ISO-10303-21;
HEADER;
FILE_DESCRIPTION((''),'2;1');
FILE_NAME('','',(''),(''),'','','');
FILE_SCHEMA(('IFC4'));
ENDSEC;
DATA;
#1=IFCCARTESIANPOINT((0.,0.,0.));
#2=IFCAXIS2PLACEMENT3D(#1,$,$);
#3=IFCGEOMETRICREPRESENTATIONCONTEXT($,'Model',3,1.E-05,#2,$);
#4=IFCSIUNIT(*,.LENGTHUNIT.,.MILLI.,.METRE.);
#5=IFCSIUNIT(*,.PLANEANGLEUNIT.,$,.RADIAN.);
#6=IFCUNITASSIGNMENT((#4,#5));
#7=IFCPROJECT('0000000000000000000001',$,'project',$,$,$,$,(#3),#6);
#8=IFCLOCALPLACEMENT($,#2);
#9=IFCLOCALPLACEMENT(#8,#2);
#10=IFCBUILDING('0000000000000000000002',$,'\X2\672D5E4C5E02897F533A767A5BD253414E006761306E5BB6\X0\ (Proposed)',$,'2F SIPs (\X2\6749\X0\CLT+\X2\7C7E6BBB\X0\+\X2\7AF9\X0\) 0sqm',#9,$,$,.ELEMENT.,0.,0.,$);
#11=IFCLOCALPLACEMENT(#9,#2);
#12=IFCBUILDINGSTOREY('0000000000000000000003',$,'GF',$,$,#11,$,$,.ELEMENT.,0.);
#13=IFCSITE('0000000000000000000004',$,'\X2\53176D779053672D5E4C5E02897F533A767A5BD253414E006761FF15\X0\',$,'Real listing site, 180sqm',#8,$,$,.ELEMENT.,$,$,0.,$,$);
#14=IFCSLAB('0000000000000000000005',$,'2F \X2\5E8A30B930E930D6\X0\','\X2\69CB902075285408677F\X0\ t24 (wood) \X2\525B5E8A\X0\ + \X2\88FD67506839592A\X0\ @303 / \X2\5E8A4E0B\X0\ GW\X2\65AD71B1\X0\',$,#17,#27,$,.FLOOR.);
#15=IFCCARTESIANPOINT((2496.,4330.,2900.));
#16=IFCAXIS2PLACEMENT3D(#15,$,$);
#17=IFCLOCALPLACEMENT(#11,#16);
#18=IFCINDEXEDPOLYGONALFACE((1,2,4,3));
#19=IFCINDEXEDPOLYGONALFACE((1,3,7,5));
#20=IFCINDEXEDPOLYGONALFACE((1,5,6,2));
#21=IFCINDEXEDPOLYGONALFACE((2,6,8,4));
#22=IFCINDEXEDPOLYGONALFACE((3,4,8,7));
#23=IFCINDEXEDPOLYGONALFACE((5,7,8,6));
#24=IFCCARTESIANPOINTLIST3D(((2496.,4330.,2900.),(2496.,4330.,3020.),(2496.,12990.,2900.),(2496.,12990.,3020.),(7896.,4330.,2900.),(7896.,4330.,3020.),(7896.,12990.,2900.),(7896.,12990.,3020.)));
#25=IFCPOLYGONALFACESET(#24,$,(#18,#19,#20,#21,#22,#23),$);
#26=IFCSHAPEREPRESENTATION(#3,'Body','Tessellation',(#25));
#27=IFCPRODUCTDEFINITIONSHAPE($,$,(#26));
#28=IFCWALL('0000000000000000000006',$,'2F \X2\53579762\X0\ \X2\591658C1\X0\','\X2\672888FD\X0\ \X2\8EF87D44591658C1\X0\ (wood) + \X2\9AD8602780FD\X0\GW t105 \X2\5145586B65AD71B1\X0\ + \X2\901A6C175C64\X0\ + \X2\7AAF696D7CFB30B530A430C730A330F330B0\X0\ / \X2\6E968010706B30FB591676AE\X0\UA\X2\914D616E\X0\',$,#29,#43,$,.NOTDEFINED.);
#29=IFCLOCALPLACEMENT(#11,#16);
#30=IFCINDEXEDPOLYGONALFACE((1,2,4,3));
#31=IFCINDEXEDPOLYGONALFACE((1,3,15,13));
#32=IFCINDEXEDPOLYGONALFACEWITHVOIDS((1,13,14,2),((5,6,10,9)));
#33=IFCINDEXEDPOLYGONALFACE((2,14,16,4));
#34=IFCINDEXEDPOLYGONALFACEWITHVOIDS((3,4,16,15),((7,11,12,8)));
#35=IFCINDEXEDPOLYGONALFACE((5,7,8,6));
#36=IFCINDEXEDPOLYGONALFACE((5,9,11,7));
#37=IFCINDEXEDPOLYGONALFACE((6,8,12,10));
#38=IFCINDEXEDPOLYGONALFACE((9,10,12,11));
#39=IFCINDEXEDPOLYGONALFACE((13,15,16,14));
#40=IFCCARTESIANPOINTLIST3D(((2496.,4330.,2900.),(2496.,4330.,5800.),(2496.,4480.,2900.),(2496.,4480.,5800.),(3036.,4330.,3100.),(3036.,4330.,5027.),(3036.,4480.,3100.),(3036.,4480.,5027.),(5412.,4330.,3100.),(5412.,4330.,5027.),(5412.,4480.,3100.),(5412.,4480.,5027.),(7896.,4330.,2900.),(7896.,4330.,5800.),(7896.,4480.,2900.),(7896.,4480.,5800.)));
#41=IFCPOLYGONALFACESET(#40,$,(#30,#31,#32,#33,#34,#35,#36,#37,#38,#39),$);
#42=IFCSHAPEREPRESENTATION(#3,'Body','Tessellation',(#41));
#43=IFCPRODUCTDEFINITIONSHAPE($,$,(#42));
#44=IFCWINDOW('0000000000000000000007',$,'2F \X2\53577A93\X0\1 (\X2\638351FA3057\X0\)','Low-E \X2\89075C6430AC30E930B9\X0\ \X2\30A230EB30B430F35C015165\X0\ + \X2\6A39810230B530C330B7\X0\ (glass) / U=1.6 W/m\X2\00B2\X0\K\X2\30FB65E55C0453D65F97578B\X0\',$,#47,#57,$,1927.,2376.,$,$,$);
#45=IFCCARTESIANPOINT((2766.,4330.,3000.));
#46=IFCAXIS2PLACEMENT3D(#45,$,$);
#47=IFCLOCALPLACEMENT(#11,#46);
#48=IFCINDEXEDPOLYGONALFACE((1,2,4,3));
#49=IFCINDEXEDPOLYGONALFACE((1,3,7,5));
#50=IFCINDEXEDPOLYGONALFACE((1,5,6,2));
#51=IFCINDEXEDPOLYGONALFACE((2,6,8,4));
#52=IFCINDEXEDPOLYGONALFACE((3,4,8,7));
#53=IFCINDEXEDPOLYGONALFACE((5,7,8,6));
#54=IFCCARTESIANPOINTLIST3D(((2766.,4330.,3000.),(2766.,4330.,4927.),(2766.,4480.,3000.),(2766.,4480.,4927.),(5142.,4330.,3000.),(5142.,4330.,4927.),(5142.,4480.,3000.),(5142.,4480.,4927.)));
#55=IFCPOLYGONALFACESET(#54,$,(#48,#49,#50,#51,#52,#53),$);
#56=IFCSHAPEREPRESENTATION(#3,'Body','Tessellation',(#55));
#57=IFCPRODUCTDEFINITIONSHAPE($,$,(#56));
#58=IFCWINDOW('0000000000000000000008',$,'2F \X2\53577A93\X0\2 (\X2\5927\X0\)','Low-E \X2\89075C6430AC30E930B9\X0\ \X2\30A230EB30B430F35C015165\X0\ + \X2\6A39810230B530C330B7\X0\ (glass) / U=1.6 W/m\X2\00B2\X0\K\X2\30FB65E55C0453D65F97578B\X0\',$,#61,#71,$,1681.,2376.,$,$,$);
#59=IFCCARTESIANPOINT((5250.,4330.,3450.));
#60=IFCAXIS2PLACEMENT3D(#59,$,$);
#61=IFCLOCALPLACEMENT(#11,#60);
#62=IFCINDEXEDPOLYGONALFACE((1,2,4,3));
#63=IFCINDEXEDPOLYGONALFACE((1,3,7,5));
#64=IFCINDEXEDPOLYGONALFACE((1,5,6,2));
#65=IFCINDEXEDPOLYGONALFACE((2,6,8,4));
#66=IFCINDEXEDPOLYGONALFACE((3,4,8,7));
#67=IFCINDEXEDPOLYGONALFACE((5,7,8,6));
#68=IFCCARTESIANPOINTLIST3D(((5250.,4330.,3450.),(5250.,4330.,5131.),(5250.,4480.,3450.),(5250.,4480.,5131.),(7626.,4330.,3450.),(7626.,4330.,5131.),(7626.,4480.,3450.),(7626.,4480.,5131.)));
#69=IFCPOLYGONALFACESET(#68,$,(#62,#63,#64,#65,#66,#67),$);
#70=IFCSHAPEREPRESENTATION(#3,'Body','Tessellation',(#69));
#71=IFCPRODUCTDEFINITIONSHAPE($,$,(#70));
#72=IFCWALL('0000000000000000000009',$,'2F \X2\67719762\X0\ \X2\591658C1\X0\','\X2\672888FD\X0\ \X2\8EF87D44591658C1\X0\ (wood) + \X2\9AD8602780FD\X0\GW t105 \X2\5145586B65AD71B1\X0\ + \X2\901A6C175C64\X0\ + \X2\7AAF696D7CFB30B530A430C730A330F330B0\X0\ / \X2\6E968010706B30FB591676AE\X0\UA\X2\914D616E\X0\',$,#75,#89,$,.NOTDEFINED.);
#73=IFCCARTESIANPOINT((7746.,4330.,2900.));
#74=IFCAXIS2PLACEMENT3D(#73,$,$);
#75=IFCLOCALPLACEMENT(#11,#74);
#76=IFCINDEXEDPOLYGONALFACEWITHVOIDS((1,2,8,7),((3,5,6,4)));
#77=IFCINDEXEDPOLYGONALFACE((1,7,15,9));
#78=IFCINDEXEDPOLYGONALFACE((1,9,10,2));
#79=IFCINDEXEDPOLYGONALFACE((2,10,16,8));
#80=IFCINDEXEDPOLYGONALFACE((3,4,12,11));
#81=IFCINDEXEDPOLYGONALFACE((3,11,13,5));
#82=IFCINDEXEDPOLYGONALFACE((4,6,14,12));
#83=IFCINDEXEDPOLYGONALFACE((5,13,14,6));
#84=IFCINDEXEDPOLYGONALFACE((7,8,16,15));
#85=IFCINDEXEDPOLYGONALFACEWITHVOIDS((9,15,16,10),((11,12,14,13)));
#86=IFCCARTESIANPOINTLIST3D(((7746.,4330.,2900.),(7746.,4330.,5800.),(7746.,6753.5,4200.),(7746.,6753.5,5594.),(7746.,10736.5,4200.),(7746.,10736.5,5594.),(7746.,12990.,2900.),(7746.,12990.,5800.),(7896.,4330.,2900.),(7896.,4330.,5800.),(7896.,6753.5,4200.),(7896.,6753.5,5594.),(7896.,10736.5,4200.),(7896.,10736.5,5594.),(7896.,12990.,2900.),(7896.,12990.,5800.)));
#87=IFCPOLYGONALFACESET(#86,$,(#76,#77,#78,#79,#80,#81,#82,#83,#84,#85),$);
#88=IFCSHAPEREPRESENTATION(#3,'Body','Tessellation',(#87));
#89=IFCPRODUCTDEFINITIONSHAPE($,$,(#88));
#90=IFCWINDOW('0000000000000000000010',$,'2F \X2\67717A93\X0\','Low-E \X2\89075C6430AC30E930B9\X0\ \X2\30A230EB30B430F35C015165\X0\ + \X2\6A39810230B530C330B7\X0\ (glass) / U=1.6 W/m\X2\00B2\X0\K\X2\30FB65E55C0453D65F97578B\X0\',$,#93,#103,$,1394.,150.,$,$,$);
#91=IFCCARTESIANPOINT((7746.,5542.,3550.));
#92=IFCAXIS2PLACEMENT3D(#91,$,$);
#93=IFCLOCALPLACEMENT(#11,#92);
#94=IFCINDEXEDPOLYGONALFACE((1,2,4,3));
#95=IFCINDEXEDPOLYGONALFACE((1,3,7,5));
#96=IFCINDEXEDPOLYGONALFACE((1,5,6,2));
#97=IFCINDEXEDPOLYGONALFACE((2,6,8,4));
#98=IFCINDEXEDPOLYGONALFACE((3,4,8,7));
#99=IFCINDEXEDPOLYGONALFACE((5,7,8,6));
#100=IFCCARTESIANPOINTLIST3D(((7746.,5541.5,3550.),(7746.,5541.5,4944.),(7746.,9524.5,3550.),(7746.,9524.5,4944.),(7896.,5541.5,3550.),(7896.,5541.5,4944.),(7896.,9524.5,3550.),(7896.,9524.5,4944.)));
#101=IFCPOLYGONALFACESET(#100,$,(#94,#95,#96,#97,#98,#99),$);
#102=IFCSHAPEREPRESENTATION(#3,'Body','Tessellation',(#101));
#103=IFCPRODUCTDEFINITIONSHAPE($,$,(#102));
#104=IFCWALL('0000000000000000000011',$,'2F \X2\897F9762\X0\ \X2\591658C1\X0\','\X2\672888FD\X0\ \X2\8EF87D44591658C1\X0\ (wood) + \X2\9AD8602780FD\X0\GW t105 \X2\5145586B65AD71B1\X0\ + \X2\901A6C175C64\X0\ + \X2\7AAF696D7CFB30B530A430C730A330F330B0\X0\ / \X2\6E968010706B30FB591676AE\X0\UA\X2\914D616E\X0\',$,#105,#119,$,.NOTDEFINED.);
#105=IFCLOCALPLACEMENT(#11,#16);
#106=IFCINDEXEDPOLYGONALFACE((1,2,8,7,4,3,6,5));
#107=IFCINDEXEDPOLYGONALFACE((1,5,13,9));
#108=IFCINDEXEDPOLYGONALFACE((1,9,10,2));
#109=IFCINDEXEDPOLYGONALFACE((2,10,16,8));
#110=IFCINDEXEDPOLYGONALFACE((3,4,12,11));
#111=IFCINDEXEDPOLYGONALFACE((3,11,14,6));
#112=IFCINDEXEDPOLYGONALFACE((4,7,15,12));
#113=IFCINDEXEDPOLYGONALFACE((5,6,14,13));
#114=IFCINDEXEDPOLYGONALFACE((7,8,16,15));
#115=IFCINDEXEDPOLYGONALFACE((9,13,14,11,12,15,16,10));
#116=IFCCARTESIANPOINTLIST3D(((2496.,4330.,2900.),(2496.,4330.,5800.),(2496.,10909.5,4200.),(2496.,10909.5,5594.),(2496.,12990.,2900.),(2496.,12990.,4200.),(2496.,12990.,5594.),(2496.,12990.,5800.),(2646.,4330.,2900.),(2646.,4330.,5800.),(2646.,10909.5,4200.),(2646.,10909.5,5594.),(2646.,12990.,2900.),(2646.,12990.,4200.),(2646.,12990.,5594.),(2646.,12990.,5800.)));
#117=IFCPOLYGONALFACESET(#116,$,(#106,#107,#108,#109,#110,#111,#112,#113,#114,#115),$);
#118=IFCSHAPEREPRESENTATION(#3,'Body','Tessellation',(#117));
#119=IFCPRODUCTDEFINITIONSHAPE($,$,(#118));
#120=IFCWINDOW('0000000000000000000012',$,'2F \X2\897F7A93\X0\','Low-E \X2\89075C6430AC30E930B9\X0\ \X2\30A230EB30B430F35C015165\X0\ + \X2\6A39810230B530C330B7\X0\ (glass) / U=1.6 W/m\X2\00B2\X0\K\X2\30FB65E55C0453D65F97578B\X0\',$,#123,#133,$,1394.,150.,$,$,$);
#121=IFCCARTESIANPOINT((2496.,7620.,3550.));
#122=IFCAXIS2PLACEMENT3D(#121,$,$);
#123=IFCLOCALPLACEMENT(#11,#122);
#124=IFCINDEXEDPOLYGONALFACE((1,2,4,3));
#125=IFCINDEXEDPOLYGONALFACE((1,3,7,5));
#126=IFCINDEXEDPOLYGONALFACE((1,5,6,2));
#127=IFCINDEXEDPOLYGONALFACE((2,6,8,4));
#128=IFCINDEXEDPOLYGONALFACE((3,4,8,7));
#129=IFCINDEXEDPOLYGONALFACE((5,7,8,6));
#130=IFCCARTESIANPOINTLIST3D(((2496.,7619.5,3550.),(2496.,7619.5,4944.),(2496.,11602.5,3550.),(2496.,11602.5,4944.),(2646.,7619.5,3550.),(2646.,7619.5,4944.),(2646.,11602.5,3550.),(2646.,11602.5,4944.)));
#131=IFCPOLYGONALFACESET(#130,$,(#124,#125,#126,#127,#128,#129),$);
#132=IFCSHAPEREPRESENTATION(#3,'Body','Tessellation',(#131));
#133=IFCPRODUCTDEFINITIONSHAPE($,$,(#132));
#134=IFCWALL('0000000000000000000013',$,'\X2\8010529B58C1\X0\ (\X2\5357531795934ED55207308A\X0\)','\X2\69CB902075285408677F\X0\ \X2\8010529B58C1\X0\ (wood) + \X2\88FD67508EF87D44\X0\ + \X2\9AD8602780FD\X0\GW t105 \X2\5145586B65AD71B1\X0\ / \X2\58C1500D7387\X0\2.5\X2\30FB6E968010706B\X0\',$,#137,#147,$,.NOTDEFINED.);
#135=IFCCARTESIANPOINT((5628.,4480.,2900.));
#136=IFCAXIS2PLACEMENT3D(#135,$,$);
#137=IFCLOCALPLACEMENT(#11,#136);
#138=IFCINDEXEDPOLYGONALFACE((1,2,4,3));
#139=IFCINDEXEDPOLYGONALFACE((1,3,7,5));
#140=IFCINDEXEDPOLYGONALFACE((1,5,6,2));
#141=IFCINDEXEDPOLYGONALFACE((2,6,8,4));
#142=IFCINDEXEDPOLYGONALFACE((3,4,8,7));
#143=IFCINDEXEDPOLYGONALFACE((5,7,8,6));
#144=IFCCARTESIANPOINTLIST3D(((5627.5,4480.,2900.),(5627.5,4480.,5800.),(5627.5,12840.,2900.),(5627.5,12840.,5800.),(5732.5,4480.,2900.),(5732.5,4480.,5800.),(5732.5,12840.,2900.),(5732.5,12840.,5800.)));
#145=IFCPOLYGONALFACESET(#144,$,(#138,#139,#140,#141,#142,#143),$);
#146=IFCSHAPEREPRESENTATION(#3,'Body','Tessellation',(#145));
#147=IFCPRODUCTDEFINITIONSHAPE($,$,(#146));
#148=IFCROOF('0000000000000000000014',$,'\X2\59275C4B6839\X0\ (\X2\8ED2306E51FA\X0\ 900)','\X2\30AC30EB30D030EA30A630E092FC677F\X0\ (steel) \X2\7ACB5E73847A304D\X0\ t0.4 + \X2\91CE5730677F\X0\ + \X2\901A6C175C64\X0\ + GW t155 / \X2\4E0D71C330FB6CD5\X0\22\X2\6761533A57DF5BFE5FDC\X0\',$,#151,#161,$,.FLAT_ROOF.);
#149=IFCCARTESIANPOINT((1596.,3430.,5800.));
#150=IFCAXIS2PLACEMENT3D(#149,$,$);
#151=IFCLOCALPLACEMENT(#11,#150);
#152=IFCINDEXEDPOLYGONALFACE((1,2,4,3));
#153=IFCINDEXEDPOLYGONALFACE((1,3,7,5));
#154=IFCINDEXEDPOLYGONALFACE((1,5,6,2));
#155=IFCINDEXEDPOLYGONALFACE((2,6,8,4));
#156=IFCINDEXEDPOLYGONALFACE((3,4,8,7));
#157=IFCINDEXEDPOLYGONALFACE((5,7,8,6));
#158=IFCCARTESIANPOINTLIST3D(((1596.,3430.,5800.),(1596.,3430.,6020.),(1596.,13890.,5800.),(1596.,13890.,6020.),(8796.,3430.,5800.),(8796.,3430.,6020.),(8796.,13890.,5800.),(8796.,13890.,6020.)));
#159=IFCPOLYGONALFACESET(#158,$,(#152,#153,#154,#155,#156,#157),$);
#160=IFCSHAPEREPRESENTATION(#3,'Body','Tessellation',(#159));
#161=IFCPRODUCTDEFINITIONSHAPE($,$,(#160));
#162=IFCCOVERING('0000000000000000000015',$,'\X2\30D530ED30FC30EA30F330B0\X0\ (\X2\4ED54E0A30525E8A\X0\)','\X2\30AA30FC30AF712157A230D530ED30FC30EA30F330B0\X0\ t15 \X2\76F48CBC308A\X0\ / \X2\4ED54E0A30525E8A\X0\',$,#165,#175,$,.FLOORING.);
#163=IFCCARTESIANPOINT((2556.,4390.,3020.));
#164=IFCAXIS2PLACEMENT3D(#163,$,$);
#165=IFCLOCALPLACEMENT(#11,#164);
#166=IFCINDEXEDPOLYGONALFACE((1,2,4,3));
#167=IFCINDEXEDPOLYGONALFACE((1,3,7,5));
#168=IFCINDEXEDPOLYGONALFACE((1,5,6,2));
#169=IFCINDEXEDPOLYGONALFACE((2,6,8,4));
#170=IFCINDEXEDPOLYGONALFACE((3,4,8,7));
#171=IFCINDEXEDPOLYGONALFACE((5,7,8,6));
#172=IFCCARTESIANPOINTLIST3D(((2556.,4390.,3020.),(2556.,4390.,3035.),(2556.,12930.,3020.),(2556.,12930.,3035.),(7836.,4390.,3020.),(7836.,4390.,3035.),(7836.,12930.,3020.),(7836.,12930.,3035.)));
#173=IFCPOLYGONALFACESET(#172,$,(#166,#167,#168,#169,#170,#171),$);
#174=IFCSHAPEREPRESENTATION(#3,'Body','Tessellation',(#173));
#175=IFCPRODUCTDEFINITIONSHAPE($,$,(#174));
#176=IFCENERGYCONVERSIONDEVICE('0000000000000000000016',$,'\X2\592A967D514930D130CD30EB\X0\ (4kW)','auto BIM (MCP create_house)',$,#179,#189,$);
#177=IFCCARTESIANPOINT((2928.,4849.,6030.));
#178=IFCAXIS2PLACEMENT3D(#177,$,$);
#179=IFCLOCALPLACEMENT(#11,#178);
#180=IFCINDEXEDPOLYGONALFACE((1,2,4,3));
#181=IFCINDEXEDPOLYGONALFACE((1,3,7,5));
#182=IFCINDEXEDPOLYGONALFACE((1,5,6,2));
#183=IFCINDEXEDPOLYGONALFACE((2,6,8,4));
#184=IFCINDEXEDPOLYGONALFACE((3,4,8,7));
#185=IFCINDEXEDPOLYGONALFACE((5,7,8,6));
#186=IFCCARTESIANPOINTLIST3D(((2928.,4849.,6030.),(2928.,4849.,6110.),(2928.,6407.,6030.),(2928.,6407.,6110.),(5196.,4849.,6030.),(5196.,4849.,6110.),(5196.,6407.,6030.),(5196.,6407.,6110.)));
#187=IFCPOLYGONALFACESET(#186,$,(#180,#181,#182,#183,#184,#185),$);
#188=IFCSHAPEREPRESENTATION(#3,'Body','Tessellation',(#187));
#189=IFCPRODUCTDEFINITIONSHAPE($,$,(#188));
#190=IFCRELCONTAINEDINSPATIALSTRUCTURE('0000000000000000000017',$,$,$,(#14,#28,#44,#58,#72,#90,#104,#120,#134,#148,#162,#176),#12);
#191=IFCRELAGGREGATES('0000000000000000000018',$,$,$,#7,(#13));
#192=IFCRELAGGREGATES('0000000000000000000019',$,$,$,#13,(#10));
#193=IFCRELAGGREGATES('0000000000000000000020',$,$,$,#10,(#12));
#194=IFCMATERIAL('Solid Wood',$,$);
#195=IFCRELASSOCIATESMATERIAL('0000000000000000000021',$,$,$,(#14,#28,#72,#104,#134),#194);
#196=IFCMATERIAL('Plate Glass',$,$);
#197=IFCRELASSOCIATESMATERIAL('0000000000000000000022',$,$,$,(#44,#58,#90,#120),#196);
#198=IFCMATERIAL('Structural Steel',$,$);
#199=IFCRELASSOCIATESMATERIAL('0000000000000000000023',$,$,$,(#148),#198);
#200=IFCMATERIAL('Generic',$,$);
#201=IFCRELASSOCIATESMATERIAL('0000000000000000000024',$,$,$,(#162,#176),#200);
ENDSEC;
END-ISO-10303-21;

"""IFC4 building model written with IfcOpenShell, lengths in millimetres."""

from ifc_helpers import new_model, si_unit, frame, frame_2d, origin, place, context, project, spatial, rectangle, extrude, material, element, fill, save


model = new_model("IFC4")

# Units and contexts
model_context = context("Model", 3, precision=1e-05, world=origin())
ifc_project = project(units=[si_unit("LENGTHUNIT", "METRE", prefix="MILLI"), si_unit("PLANEANGLEUNIT", "RADIAN")], contexts=[model_context])

# Site, building, storey
site_placement = place(None, origin())
site = spatial("IfcSite", under=ifc_project, at=site_placement, Name="北海道札幌市西区発寒十一条５", ObjectType="Real listing site, 180sqm", CompositionType="ELEMENT", RefElevation=0.0)
building_placement = place(site_placement, origin())
building = spatial("IfcBuilding", under=site, at=building_placement, Name="札幌市西区発寒十一条の家 (Proposed)", ObjectType="2F SIPs (杉CLT+籾殻+竹) 0sqm", CompositionType="ELEMENT", ElevationOfRefHeight=0.0, ElevationOfTerrain=0.0)
storey_placement = place(building_placement, origin())
storey = spatial("IfcBuildingStorey", under=building, at=storey_placement, Name="GF", CompositionType="ELEMENT", Elevation=0.0)

# Slab
ifc_material_1 = material(Name="Solid Wood")
slab_placement = place(storey_placement, frame((2496.0, 4330.0, 2900.0)))
element("IfcSlab", 1, at=slab_placement, inside=storey, material=ifc_material_1, Name="2F 床スラブ", Description="構造用合板 t24 (wood) 剛床 + 製材根太 @303 / 床下 GW断熱", PredefinedType="FLOOR", context=model_context, shape_type="SweptSolid", body=[
    extrude(rectangle(XDim=5400.0, YDim=8660.0, at=frame_2d((2700.0, 4330.0))), frame((2496.0, 4330.0, 2900.0)), (0.0, 0.0, 1.0), 120.0),
])

# Wall, openings, windows
wall_1_placement = place(storey_placement, frame((2496.0, 4330.0, 2900.0)))
wall_1 = element("IfcWall", 2, at=wall_1_placement, inside=storey, material=ifc_material_1, Name="2F 南面 外壁", Description="木製 軸組外壁 (wood) + 高性能GW t105 充填断熱 + 通気層 + 窯業系サイディング / 準耐火・外皮UA配慮", PredefinedType="NOTDEFINED", context=model_context, shape_type="SweptSolid", body=[
    extrude(rectangle(XDim=5400.0, YDim=150.0, at=frame_2d((2700.0, 75.0))), frame((2496.0, 4330.0, 2900.0)), (0.0, 0.0, 1.0), 2900.0),
])
opening_1_placement = place(storey_placement, frame((2766.0, 4330.0, 3000.0)))
opening_1 = element("IfcOpeningElement", 3, at=opening_1_placement, cuts=wall_1, PredefinedType="NOTDEFINED", context=model_context, shape_type="SweptSolid", body=[
    extrude(rectangle(XDim=2376.0, YDim=150.0, at=frame_2d((1188.0, 75.0))), frame((2766.0, 4330.0, 3000.0)), (0.0, 0.0, 1.0), 1927.0),
])
opening_2_placement = place(storey_placement, frame((5250.0, 4330.0, 3450.0)))
opening_2 = element("IfcOpeningElement", 4, at=opening_2_placement, cuts=wall_1, PredefinedType="NOTDEFINED", context=model_context, shape_type="SweptSolid", body=[
    extrude(rectangle(XDim=2376.0, YDim=150.0, at=frame_2d((1188.0, 75.0))), frame((5250.0, 4330.0, 3450.0)), (0.0, 0.0, 1.0), 1681.0),
])
ifc_material_2 = material(Name="Plate Glass")
window_1_placement = place(storey_placement, frame((2766.0, 4330.0, 3000.0)))
window_1 = element("IfcWindow", 5, at=window_1_placement, inside=storey, material=ifc_material_2, Name="2F 南窓1 (掃出し)", Description="Low-E 複層ガラス アルゴン封入 + 樹脂サッシ (glass) / U=1.6 W/m²K・日射取得型", OverallHeight=1927.0, OverallWidth=2376.0, context=model_context, shape_type="SweptSolid", body=[
    extrude(rectangle(XDim=2376.0, YDim=150.0, at=frame_2d((1188.0, 75.0))), frame((2766.0, 4330.0, 3000.0)), (0.0, 0.0, 1.0), 1927.0),
])
fill(opening_1, window_1)
window_2_placement = place(storey_placement, frame((5250.0, 4330.0, 3450.0)))
window_2 = element("IfcWindow", 6, at=window_2_placement, inside=storey, material=ifc_material_2, Name="2F 南窓2 (大)", Description="Low-E 複層ガラス アルゴン封入 + 樹脂サッシ (glass) / U=1.6 W/m²K・日射取得型", OverallHeight=1681.0, OverallWidth=2376.0, context=model_context, shape_type="SweptSolid", body=[
    extrude(rectangle(XDim=2376.0, YDim=150.0, at=frame_2d((1188.0, 75.0))), frame((5250.0, 4330.0, 3450.0)), (0.0, 0.0, 1.0), 1681.0),
])
fill(opening_2, window_2)

# Walls, openings, windows
wall_2_placement = place(storey_placement, frame((7746.0, 4330.0, 2900.0)))
wall_2 = element("IfcWall", 7, at=wall_2_placement, inside=storey, material=ifc_material_1, Name="2F 東面 外壁", Description="木製 軸組外壁 (wood) + 高性能GW t105 充填断熱 + 通気層 + 窯業系サイディング / 準耐火・外皮UA配慮", PredefinedType="NOTDEFINED", context=model_context, shape_type="SweptSolid", body=[
    extrude(rectangle(XDim=150.0, YDim=8660.0, at=frame_2d((75.0, 4330.0))), frame((7746.0, 4330.0, 2900.0)), (0.0, 0.0, 1.0), 2900.0),
])
opening_3_placement = place(storey_placement, frame((7746.0, 5542.0, 3550.0)))
opening_3 = element("IfcOpeningElement", 8, at=opening_3_placement, cuts=wall_2, PredefinedType="NOTDEFINED", context=model_context, shape_type="SweptSolid", body=[
    extrude(rectangle(XDim=150.0, YDim=3983.0, at=frame_2d((75.0, 1991.0))), frame((7746.0, 5542.0, 3550.0)), (0.0, 0.0, 1.0), 1394.0),
])
window_3_placement = place(storey_placement, frame((7746.0, 5542.0, 3550.0)))
window_3 = element("IfcWindow", 9, at=window_3_placement, inside=storey, material=ifc_material_2, Name="2F 東窓", Description="Low-E 複層ガラス アルゴン封入 + 樹脂サッシ (glass) / U=1.6 W/m²K・日射取得型", OverallHeight=1394.0, OverallWidth=150.0, context=model_context, shape_type="SweptSolid", body=[
    extrude(rectangle(XDim=150.0, YDim=3983.0, at=frame_2d((75.0, 1991.0))), frame((7746.0, 5542.0, 3550.0)), (0.0, 0.0, 1.0), 1394.0),
])
fill(opening_3, window_3)
wall_3_placement = place(storey_placement, frame((2496.0, 4330.0, 2900.0)))
wall_3 = element("IfcWall", 10, at=wall_3_placement, inside=storey, material=ifc_material_1, Name="2F 西面 外壁", Description="木製 軸組外壁 (wood) + 高性能GW t105 充填断熱 + 通気層 + 窯業系サイディング / 準耐火・外皮UA配慮", PredefinedType="NOTDEFINED", context=model_context, shape_type="SweptSolid", body=[
    extrude(rectangle(XDim=150.0, YDim=8660.0, at=frame_2d((75.0, 4330.0))), frame((2496.0, 4330.0, 2900.0)), (0.0, 0.0, 1.0), 2900.0),
])
opening_4_placement = place(storey_placement, frame((2496.0, 7620.0, 3550.0)))
opening_4 = element("IfcOpeningElement", 11, at=opening_4_placement, cuts=wall_3, PredefinedType="NOTDEFINED", context=model_context, shape_type="SweptSolid", body=[
    extrude(rectangle(XDim=150.0, YDim=3983.0, at=frame_2d((75.0, 1991.0))), frame((2496.0, 7620.0, 3550.0)), (0.0, 0.0, 1.0), 1394.0),
])
window_4_placement = place(storey_placement, frame((2496.0, 7620.0, 3550.0)))
window_4 = element("IfcWindow", 12, at=window_4_placement, inside=storey, material=ifc_material_2, Name="2F 西窓", Description="Low-E 複層ガラス アルゴン封入 + 樹脂サッシ (glass) / U=1.6 W/m²K・日射取得型", OverallHeight=1394.0, OverallWidth=150.0, context=model_context, shape_type="SweptSolid", body=[
    extrude(rectangle(XDim=150.0, YDim=3983.0, at=frame_2d((75.0, 1991.0))), frame((2496.0, 7620.0, 3550.0)), (0.0, 0.0, 1.0), 1394.0),
])
fill(opening_4, window_4)

# Wall
wall_4_placement = place(storey_placement, frame((5628.0, 4480.0, 2900.0)))
element("IfcWall", 13, at=wall_4_placement, inside=storey, material=ifc_material_1, Name="耐力壁 (南北間仕切り)", Description="構造用合板 耐力壁 (wood) + 製材軸組 + 高性能GW t105 充填断熱 / 壁倍率2.5・準耐火", PredefinedType="NOTDEFINED", context=model_context, shape_type="SweptSolid", body=[
    extrude(rectangle(XDim=105.0, YDim=8360.0, at=frame_2d((52.0, 4180.0))), frame((5628.0, 4480.0, 2900.0)), (0.0, 0.0, 1.0), 2900.0),
])

# Roof
ifc_material_3 = material(Name="Structural Steel")
roof_placement = place(storey_placement, frame((1596.0, 3430.0, 5800.0)))
element("IfcRoof", 14, at=roof_placement, inside=storey, material=ifc_material_3, Name="大屋根 (軒の出 900)", Description="ガルバリウム鋼板 (steel) 立平葺き t0.4 + 野地板 + 通気層 + GW t155 / 不燃・法22条区域対応", PredefinedType="FLAT_ROOF", context=model_context, shape_type="SweptSolid", body=[
    extrude(rectangle(XDim=7200.0, YDim=10460.0, at=frame_2d((3600.0, 5230.0))), frame((1596.0, 3430.0, 5800.0)), (0.0, 0.0, 1.0), 220.0),
])

# Covering
ifc_material_4 = material(Name="Generic")
covering_placement = place(storey_placement, frame((2556.0, 4390.0, 3020.0)))
element("IfcCovering", 15, at=covering_placement, inside=storey, material=ifc_material_4, Name="フローリング (仕上げ床)", Description="オーク無垢フローリング t15 直貼り / 仕上げ床", PredefinedType="FLOORING", context=model_context, shape_type="SweptSolid", body=[
    extrude(rectangle(XDim=5280.0, YDim=8540.0, at=frame_2d((2640.0, 4270.0))), frame((2556.0, 4390.0, 3020.0)), (0.0, 0.0, 1.0), 15.0),
])

# Energy conversion device
energy_conversion_device_placement = place(storey_placement, frame((2928.0, 4849.0, 6030.0)))
element("IfcEnergyConversionDevice", 16, at=energy_conversion_device_placement, inside=storey, material=ifc_material_4, Name="太陽光パネル (4kW)", Description="auto BIM (MCP create_house)", context=model_context, shape_type="SweptSolid", body=[
    extrude(rectangle(XDim=2268.0, YDim=1558.0, at=frame_2d((1134.0, 779.0))), frame((2928.0, 4849.0, 6030.0)), (0.0, 0.0, 1.0), 80.0),
])

save(model, "model.ifc")
